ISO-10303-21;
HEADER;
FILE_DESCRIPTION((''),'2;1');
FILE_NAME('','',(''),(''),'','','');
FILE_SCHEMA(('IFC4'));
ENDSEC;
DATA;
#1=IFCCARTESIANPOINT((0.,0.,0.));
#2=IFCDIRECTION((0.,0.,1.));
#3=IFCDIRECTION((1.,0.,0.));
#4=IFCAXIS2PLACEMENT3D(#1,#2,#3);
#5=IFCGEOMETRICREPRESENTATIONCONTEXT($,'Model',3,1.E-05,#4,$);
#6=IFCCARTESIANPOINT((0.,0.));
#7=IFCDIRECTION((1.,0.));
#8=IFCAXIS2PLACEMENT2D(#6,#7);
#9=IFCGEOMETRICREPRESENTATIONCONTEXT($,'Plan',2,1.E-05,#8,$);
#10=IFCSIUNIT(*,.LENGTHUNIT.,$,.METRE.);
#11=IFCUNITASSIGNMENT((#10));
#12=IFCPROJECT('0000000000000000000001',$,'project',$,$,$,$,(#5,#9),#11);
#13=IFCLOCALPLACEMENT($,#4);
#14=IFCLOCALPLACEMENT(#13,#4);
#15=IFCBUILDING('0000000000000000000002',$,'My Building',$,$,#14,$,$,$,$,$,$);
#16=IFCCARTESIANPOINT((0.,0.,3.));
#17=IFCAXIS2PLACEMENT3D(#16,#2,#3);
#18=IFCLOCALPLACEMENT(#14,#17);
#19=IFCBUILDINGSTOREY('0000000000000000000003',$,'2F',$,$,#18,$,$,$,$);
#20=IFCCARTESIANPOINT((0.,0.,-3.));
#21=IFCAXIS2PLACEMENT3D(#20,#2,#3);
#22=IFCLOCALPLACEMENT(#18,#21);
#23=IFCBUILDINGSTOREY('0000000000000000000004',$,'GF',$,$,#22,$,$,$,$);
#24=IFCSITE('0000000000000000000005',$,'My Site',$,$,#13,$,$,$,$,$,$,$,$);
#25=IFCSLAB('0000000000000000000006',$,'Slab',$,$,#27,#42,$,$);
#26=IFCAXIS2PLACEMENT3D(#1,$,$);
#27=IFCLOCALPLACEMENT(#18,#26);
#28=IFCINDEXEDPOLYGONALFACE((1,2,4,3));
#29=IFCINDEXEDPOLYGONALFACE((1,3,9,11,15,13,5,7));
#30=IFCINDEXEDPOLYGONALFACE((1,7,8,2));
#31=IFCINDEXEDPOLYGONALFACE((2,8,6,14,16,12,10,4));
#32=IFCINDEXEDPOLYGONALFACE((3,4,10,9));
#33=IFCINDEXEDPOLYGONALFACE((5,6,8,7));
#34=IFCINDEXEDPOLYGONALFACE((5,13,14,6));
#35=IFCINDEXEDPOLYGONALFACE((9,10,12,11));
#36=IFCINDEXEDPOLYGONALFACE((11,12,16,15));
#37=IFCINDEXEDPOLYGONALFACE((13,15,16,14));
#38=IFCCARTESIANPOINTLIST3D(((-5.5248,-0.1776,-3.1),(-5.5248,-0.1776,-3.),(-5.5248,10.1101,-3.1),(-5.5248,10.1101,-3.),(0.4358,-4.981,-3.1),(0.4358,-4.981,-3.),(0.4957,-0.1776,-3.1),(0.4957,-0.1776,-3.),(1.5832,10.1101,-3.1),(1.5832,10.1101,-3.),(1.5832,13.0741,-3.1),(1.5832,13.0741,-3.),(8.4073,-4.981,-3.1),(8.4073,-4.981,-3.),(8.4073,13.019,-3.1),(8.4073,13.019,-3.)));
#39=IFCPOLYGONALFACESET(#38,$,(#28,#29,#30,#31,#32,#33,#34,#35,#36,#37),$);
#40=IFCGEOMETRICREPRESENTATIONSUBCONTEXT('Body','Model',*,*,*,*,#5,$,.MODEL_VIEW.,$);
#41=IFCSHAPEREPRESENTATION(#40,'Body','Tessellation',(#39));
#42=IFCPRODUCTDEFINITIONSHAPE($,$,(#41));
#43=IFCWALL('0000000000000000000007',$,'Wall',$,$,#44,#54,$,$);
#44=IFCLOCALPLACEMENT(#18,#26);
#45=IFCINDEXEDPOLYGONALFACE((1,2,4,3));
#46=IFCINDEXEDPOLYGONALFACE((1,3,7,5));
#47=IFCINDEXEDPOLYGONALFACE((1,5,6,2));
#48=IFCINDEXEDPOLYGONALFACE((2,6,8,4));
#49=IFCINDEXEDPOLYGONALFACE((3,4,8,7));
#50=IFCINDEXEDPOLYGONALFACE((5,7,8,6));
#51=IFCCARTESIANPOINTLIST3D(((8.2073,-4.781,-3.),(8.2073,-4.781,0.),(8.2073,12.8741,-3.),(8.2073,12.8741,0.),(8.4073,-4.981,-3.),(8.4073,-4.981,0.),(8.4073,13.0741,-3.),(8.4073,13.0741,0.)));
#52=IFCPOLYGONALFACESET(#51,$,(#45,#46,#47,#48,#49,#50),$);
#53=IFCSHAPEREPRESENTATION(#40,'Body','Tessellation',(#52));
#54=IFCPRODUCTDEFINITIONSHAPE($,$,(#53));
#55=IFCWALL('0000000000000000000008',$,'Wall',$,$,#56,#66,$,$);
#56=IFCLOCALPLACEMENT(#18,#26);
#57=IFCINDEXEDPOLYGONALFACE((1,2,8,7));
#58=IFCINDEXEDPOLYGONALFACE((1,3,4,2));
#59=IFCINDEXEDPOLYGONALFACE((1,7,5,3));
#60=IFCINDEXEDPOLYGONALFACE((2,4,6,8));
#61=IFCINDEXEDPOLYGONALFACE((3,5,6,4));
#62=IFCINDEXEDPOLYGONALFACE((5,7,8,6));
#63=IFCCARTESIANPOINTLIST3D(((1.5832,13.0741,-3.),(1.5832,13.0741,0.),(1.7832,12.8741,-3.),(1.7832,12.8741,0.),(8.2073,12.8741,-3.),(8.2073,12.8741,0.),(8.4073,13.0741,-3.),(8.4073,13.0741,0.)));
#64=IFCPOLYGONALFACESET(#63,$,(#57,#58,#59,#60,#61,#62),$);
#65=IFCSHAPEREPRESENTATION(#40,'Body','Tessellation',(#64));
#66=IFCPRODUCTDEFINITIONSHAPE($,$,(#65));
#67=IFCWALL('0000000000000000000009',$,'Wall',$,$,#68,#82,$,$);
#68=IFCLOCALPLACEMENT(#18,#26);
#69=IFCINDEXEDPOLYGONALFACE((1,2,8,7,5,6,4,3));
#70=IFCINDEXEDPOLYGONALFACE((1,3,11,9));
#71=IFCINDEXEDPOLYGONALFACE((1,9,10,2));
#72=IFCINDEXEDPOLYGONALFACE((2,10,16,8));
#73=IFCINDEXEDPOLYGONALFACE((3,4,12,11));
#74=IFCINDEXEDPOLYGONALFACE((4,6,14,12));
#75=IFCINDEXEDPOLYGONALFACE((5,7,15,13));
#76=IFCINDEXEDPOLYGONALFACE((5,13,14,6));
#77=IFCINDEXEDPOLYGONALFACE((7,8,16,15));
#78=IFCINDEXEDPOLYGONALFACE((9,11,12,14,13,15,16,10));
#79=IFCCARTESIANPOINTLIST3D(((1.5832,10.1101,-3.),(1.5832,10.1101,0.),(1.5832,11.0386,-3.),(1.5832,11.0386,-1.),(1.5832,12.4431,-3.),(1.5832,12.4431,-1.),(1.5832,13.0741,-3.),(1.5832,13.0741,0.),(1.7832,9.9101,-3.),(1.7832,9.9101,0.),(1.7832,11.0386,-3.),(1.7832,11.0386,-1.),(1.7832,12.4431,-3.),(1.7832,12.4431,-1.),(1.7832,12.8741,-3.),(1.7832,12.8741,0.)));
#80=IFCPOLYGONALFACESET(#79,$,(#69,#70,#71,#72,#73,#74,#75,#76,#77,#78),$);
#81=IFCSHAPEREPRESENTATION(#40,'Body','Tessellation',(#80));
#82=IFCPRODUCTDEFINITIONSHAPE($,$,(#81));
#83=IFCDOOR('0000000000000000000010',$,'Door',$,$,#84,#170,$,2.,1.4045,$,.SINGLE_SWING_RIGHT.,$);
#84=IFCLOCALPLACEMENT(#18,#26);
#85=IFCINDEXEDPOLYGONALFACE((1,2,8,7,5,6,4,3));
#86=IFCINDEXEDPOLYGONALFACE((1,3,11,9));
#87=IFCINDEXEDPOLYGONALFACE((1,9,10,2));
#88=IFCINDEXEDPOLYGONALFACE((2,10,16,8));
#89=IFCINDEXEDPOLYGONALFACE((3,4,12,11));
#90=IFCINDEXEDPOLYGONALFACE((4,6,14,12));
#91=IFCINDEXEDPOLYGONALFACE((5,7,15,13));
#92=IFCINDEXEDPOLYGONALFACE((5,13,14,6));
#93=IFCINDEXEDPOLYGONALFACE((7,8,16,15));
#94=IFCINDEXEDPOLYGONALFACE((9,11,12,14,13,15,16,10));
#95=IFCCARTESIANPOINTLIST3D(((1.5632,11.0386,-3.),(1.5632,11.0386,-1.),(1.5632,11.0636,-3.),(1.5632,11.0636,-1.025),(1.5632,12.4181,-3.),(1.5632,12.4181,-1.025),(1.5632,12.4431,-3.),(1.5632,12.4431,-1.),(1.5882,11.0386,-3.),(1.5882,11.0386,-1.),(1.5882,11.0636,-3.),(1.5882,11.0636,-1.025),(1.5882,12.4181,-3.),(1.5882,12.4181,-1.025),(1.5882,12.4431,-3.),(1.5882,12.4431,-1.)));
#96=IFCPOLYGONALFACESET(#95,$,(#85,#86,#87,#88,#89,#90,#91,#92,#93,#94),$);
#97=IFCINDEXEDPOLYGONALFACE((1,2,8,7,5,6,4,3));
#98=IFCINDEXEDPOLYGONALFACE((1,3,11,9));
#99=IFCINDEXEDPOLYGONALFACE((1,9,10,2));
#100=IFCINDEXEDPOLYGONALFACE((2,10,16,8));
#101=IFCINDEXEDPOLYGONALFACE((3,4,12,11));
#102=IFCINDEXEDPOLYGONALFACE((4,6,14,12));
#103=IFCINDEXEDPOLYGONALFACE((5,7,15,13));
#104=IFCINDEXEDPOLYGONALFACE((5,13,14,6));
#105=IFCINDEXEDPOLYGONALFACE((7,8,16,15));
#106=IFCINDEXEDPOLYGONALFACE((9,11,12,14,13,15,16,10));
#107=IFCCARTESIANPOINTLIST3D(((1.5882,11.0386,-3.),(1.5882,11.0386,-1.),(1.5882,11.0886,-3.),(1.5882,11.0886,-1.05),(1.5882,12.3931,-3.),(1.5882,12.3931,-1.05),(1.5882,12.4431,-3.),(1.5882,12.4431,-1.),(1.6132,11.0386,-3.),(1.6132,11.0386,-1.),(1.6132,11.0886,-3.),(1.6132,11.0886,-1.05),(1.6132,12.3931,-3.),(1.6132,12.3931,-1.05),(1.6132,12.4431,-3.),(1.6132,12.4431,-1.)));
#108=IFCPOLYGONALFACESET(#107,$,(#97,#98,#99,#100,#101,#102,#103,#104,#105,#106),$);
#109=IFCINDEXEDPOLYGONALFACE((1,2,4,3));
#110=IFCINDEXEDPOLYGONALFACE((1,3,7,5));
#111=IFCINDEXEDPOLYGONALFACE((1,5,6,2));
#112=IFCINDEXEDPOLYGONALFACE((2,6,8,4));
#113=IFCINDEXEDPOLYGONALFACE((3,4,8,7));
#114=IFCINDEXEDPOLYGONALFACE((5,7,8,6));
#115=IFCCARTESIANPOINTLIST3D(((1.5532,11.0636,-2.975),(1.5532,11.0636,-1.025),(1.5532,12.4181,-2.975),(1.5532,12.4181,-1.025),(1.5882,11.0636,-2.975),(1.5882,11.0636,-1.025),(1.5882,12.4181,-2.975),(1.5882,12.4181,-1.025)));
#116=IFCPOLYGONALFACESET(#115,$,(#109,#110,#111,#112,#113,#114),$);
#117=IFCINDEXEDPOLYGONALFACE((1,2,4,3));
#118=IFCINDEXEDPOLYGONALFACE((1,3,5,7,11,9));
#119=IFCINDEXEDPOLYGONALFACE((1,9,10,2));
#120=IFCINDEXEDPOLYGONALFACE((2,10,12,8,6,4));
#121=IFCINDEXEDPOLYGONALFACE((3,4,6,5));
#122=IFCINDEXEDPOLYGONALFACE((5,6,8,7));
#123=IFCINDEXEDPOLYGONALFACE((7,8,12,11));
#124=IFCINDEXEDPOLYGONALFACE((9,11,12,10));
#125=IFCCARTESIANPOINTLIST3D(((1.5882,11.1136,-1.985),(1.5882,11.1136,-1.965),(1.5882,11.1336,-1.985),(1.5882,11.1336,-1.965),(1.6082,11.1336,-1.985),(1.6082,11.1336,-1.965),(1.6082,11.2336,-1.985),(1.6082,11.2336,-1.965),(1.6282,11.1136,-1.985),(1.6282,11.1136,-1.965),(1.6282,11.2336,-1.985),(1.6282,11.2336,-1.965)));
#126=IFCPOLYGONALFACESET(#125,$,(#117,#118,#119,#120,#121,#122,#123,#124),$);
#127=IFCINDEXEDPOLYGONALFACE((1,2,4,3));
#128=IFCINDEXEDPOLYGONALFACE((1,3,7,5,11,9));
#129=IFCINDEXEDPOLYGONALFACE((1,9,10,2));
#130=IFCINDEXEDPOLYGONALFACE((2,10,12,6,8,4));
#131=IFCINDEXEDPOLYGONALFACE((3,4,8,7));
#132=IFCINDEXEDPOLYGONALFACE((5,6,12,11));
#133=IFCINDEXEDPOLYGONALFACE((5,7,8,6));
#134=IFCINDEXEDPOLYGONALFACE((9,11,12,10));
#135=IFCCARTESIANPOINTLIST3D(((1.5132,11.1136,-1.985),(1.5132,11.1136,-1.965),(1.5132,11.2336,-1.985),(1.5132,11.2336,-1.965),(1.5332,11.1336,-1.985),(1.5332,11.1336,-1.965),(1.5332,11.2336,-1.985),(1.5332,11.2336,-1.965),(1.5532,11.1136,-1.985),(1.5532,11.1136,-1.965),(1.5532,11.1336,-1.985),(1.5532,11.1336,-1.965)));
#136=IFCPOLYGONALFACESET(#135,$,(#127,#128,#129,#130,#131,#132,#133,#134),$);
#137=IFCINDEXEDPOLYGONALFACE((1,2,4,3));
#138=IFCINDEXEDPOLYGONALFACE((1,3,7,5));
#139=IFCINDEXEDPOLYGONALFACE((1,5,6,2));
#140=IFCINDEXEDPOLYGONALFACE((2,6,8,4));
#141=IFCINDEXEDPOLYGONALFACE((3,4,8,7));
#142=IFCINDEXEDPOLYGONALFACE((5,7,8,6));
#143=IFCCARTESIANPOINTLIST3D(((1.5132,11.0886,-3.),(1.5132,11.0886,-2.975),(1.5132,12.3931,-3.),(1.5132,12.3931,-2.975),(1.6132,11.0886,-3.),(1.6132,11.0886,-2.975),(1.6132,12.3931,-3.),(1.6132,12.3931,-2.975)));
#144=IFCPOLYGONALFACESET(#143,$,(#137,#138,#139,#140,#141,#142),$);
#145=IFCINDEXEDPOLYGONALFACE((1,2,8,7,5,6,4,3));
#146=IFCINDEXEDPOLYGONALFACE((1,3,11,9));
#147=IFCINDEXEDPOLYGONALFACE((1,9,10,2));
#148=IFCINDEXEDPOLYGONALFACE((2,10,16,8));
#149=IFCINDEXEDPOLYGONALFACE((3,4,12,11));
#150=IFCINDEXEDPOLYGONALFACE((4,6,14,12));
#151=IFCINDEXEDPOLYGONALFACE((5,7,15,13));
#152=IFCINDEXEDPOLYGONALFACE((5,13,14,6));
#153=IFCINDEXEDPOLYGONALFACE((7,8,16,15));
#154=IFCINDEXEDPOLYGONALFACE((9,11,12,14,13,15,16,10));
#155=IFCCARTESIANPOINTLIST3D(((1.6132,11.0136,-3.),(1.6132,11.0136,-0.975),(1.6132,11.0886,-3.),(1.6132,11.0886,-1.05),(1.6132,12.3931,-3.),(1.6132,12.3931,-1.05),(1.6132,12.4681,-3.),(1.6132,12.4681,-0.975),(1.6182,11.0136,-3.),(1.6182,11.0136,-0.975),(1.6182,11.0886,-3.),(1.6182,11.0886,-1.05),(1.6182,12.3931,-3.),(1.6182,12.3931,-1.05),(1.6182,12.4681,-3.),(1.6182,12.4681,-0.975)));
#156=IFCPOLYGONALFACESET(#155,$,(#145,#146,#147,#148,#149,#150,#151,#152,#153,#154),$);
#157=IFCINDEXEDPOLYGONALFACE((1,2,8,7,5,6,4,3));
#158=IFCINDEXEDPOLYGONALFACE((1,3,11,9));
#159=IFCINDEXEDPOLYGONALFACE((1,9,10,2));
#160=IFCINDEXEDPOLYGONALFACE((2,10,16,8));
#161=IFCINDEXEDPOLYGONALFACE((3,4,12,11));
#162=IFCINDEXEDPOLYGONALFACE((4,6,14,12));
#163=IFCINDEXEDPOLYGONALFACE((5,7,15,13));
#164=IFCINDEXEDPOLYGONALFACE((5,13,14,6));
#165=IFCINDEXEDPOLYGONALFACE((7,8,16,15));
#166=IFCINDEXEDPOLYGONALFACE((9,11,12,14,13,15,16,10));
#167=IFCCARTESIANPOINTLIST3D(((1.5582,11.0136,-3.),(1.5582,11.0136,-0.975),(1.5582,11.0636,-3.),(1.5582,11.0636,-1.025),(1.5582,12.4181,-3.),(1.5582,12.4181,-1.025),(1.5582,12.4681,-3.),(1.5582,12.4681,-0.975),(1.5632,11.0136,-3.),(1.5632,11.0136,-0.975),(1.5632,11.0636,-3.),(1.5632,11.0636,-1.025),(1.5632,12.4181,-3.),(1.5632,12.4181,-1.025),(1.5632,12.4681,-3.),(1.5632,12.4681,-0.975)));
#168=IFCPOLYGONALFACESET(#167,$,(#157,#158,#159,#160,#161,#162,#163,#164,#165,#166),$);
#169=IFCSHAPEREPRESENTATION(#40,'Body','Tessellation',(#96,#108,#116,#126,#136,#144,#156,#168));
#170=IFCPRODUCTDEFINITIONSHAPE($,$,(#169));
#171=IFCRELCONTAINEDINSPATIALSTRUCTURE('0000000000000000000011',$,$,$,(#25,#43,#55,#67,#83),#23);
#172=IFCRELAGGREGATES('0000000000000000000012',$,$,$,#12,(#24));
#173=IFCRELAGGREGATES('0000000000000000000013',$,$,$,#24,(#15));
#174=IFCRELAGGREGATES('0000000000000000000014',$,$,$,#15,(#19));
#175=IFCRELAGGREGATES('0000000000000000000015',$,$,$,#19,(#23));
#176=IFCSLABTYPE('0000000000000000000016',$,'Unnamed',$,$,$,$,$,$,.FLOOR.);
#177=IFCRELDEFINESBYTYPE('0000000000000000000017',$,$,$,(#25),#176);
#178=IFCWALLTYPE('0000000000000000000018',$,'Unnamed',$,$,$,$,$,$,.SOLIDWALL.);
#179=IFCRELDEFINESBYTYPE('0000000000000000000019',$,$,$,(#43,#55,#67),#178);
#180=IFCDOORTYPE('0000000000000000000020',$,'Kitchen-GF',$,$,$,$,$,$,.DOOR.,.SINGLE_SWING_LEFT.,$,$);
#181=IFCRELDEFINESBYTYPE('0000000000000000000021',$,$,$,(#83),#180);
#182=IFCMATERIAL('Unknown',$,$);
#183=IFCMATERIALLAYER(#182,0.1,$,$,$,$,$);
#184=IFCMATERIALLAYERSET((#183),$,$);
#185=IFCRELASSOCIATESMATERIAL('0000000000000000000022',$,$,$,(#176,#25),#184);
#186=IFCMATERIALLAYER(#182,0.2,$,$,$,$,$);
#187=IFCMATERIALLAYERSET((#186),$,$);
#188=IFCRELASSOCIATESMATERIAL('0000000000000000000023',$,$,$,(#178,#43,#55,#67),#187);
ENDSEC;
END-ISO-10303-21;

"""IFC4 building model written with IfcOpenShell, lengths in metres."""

from ifc_helpers import new_model, entity, si_unit, frame, origin_with_axes, origin_2d_with_axis, place, context, subcontext, project, spatial, line, indexed_curve, outline, extrude, shape, source, transform, mapped, material, layer, layer_set, layer_usage, type_object, type_shapes, element, fill, save


model = new_model("IFC4")

# Units and contexts
model_context = context("Model", 3, precision=1e-05, world=origin_with_axes())
plan_context = context("Plan", 2, precision=1e-05, world=origin_2d_with_axis())
body_context_1 = subcontext(model_context, "Body", "Model", "MODEL_VIEW")
body_context_2 = subcontext(plan_context, "Body", "Plan", "PLAN_VIEW")
ifc_project = project(units=[si_unit("LENGTHUNIT", "METRE")], contexts=[model_context, plan_context])

# Site, building, storeys
site_placement = place(None, origin_with_axes())
site = spatial("IfcSite", under=ifc_project, at=site_placement, Name="My Site")
building_placement = place(site_placement, origin_with_axes())
building = spatial("IfcBuilding", under=site, at=building_placement, Name="My Building")
storey_1_placement = place(building_placement, frame((0.0, 0.0, 3.0), z_axis=(0.0, 0.0, 1.0), x_axis=(1.0, 0.0, 0.0)))
storey_1 = spatial("IfcBuildingStorey", under=building, at=storey_1_placement, Name="2F")
storey_2_placement = place(storey_1_placement, frame((0.0, 0.0, -3.0), z_axis=(0.0, 0.0, 1.0), x_axis=(1.0, 0.0, 0.0)))
storey_2 = spatial("IfcBuildingStorey", under=storey_1, at=storey_2_placement, Name="GF")

# Slab
ifc_material = material(Name="Unknown")
ifc_layer_1 = layer(ifc_material, 0.1)
ifc_layer_set_1 = layer_set([ifc_layer_1])
ifc_layer_usage_1 = layer_usage(ifc_layer_set_1, "AXIS3", "POSITIVE", -0.1)
slab_type = type_object("IfcSlabType", Name="Unnamed", PredefinedType="FLOOR", material=ifc_layer_set_1)
slab_placement = place(storey_2_placement, frame((8.4073, -4.981, 0.0), z_axis=(0.0, 0.0, 1.0), x_axis=(1.0, 0.0, 0.0)))
element("IfcSlab", 1, at=slab_placement, inside=storey_2, type_object=slab_type, material=ifc_layer_usage_1, Name="Slab", context=body_context_1, shape_type="SweptSolid", body=[
    extrude(outline(indexed_curve([(0.0, 0.0), (0.0, 18.0), (-6.8241, 18.055), (-6.8241, 15.091), (-13.9321, 15.091), (-13.9321, 4.8033), (-7.9116, 4.8033), (-7.9715, 0.0), (0.0, 0.0)])), frame((0.0, 0.0, -0.1), z_axis=(0.0, 0.0, 1.0), x_axis=(1.0, 0.0, 0.0)), (0.0, 0.0, 1.0), 0.1),
])

# Shared definitions
ifc_layer_2 = layer(ifc_material, 0.2)
ifc_layer_set_2 = layer_set([ifc_layer_2])
wall_type = type_object("IfcWallType", Name="Unnamed", PredefinedType="SOLIDWALL", material=ifc_layer_set_2)

# Walls
ifc_layer_usage_2 = layer_usage(ifc_layer_set_2, "AXIS2", "POSITIVE", 0.0)
wall_1_placement = place(storey_2_placement, frame((8.4073, -4.981, 0.0), z_axis=(0.0, 0.0, 1.0), x_axis=(0.0, 1.0, 0.0)))
element("IfcWall", 2, at=wall_1_placement, inside=storey_2, type_object=wall_type, material=ifc_layer_usage_2, Name="Wall", context=body_context_1, shape_type="SweptSolid", body=[
    extrude(outline(indexed_curve([(0.0, 0.0), (0.2, 0.2), (17.855, 0.2), (18.055, 0.0)], segments=[line(1, 2, 3, 4, 1)])), origin_with_axes(), (0.0, 0.0, 1.0), 3.0),
])
ifc_layer_usage_3 = layer_usage(ifc_layer_set_2, "AXIS2", "POSITIVE", 0.0)
wall_2_placement = place(storey_2_placement, frame((8.4073, 13.0741, 0.0), z_axis=(0.0, 0.0, 1.0), x_axis=(-1.0, 0.0, 0.0)))
element("IfcWall", 3, at=wall_2_placement, inside=storey_2, type_object=wall_type, material=ifc_layer_usage_3, Name="Wall", context=body_context_1, shape_type="SweptSolid", body=[
    extrude(outline(indexed_curve([(0.0, 0.0), (0.2, 0.2), (6.6241, 0.2), (6.8241, 0.0)], segments=[line(1, 2, 3, 4, 1)])), origin_with_axes(), (0.0, 0.0, 1.0), 3.0),
])

# Wall, opening, door
ifc_layer_usage_4 = layer_usage(ifc_layer_set_2, "AXIS2", "POSITIVE", 0.0)
wall_3_placement = place(storey_2_placement, frame((1.5832, 13.0741, 0.0), z_axis=(0.0, 0.0, 1.0), x_axis=(0.0, -1.0, 0.0)))
wall_3 = element("IfcWall", 4, at=wall_3_placement, inside=storey_2, type_object=wall_type, material=ifc_layer_usage_4, Name="Wall", context=body_context_1, shape_type="SweptSolid", body=[
    extrude(outline(indexed_curve([(0.0, 0.0), (0.2, 0.2), (3.164, 0.2), (2.964, 0.0)], segments=[line(1, 2, 3, 4, 1)])), origin_with_axes(), (0.0, 0.0, 1.0), 3.0),
])
shared_shape_1 = source(origin_with_axes(), body_context_1, "Body", "SweptSolid", [
    extrude(outline(indexed_curve([(0.0, 0.0), (1.4045, 0.0), (1.4045, 2.0), (0.0, 2.0)], segments=[line(1, 2, 3, 4, 1)])), frame((0.0, -0.6, 0.0), z_axis=(0.0, -1.0, 0.0), x_axis=(1.0, 0.0, 0.0)), (0.0, 0.0, -1.0), 1.2),
])
opening_1_placement = place(wall_3_placement, frame((2.0355, 0.03, 0.0), z_axis=(0.0, 0.0, 1.0), x_axis=(-1.0, 0.0, 0.0)))
opening_1 = element("IfcOpeningElement", 5, at=opening_1_placement, cuts=wall_3, PredefinedType="OPENING", context=body_context_1, shape_type="MappedRepresentation", body=[
    mapped(shared_shape_1, transform((0.0, 0.0, 0.0), x_axis=(1.0, 0.0, 0.0), y_axis=(0.0, 1.0, 0.0), z_axis=(0.0, 0.0, 1.0), scale=1.0)),
])
door_type_1 = type_object("IfcDoorType", Name="Kitchen-GF", OperationType="SINGLE_SWING_LEFT", PredefinedType="DOOR")
shared_shape_2 = source(origin_with_axes(), body_context_1, "Body", "SweptSolid", [
    extrude(outline(indexed_curve([(0.0, 0.0), (0.0, 2.0), (1.4045, 2.0), (1.4045, 0.0), (1.3795, 0.0), (1.3795, 1.975), (0.025, 1.975), (0.025, 0.0)], segments=[line(1, 2, 3, 4, 5, 6, 7, 8, 1)])), frame((0.0, 0.025, 0.0), z_axis=(0.0, -1.0, 0.0), x_axis=(1.0, 0.0, 0.0)), (0.0, 0.0, -1.0), 0.025),
    extrude(outline(indexed_curve([(0.0, 0.0), (0.0, 2.0), (1.4045, 2.0), (1.4045, 0.0), (1.3545, 0.0), (1.3545, 1.95), (0.05, 1.95), (0.05, 0.0)], segments=[line(1, 2, 3, 4, 5, 6, 7, 8, 1)])), frame((0.0, 0.0, 0.0), z_axis=(0.0, -1.0, 0.0), x_axis=(1.0, 0.0, 0.0)), (0.0, 0.0, -1.0), 0.025),
    extrude(outline(indexed_curve([(0.0, 0.0), (1.3545, 0.0), (1.3545, 0.035), (0.0, 0.035)], segments=[line(1, 2, 3, 4, 1)])), frame((0.025, 0.025, 0.025), z_axis=(0.0, 0.0, 1.0), x_axis=(1.0, 0.0, 0.0)), (0.0, 0.0, 1.0), 1.95),
    extrude(outline(indexed_curve([(0.0, 0.0), (0.0, -0.04), (0.12, -0.04), (0.12, -0.02), (0.02, -0.02), (0.02, 0.0)], segments=[line(1, 2, 3, 4, 5, 6, 1)])), frame((0.075, 0.025, 1.015), z_axis=(0.0, 0.0, 1.0), x_axis=(1.0, 0.0, 0.0)), (0.0, 0.0, 1.0), 0.02),
    extrude(outline(indexed_curve([(0.0, 0.0), (0.0, 0.04), (0.12, 0.04), (0.12, 0.02), (0.02, 0.02), (0.02, 0.0)], segments=[line(1, 2, 3, 4, 5, 6, 1)])), frame((0.075, 0.06, 1.015), z_axis=(0.0, 0.0, 1.0), x_axis=(1.0, 0.0, 0.0)), (0.0, 0.0, 1.0), 0.02),
    extrude(outline(indexed_curve([(0.0, 0.0), (1.3045, 0.0), (1.3045, 0.1), (0.0, 0.1)], segments=[line(1, 2, 3, 4, 1)])), frame((0.05, 0.0, 0.0), z_axis=(0.0, 0.0, 1.0), x_axis=(1.0, 0.0, 0.0)), (0.0, 0.0, 1.0), 0.025),
    extrude(outline(indexed_curve([(0.0, 0.0), (0.0, 2.025), (1.4545, 2.025), (1.4545, 0.0), (1.3795, 0.0), (1.3795, 1.95), (0.075, 1.95), (0.075, 0.0)], segments=[line(1, 2, 3, 4, 5, 6, 7, 8, 1)])), frame((-0.025, -0.005, 0.0), z_axis=(0.0, -1.0, 0.0), x_axis=(1.0, 0.0, 0.0)), (0.0, 0.0, -1.0), 0.005),
    extrude(outline(indexed_curve([(0.0, 0.0), (0.0, 2.025), (1.4545, 2.025), (1.4545, 0.0), (1.4045, 0.0), (1.4045, 1.975), (0.05, 1.975), (0.05, 0.0)], segments=[line(1, 2, 3, 4, 5, 6, 7, 8, 1)])), frame((-0.025, 0.05, 0.0), z_axis=(0.0, -1.0, 0.0), x_axis=(1.0, 0.0, 0.0)), (0.0, 0.0, -1.0), 0.005),
])
shared_shape_3 = source(origin_with_axes(), body_context_2, "Body", "Curve2D", [
    entity("IfcIndexedPolyCurve", entity("IfcCartesianPointList2D", [[0.0, 0.0], [0.0, 0.05], [0.025, 0.05], [0.025, 0.025], [0.05, 0.025], [0.05, 0.0]]), [entity("IfcLineIndex", [1, 2, 3, 4, 5, 6, 1])]),
    entity("IfcIndexedPolyCurve", entity("IfcCartesianPointList2D", [[1.4045, 0.0], [1.4045, 0.05], [1.3795, 0.05], [1.3795, 0.025], [1.3545, 0.025], [1.3545, 0.0]]), [entity("IfcLineIndex", [1, 2, 3, 4, 5, 6, 1])]),
    entity("IfcTrimmedCurve", entity("IfcEllipse", entity("IfcAxis2Placement2D", entity("IfcCartesianPoint", [1.3445, 0.05]), entity("IfcDirection", [1.0, 0.0])), 1.3195, 1.3545), [entity("IfcCartesianPoint", [1.3445, 1.4045])], [entity("IfcCartesianPoint", [0.025, 0.05])], True, "CARTESIAN"),
    entity("IfcIndexedPolyCurve", entity("IfcCartesianPointList2D", [[1.3795, 0.05], [1.3445, 0.05], [1.3445, 1.4045], [1.3795, 1.4045]]), [entity("IfcLineIndex", [1, 2, 3, 4, 1])]),
])
type_shapes(door_type_1, [shared_shape_2, shared_shape_3])
door_1_placement = place(opening_1_placement, frame((0.0, 0.0, 0.0), z_axis=(0.0, 0.0, 1.0), x_axis=(1.0, 0.0, 0.0)))
door_1 = element("IfcDoor", 6, at=door_1_placement, inside=storey_2, type_object=door_type_1, Name="Door", OperationType="SINGLE_SWING_RIGHT", OverallHeight=2.0, OverallWidth=1.4045, shapes=[
    shape(body_context_1, "Body", "MappedRepresentation", [mapped(shared_shape_2, transform((0.0, 0.0, 0.0), x_axis=(1.0, 0.0, 0.0), y_axis=(0.0, 1.0, 0.0), z_axis=(0.0, 0.0, 1.0), scale=1.0))]),
    shape(body_context_2, "Body", "MappedRepresentation", [mapped(shared_shape_3, transform((0.0, 0.0, 0.0), x_axis=(1.0, 0.0, 0.0), y_axis=(0.0, 1.0, 0.0), z_axis=(0.0, 0.0, 1.0), scale=1.0))]),
])
fill(opening_1, door_1)

save(model, "model.ifc")
